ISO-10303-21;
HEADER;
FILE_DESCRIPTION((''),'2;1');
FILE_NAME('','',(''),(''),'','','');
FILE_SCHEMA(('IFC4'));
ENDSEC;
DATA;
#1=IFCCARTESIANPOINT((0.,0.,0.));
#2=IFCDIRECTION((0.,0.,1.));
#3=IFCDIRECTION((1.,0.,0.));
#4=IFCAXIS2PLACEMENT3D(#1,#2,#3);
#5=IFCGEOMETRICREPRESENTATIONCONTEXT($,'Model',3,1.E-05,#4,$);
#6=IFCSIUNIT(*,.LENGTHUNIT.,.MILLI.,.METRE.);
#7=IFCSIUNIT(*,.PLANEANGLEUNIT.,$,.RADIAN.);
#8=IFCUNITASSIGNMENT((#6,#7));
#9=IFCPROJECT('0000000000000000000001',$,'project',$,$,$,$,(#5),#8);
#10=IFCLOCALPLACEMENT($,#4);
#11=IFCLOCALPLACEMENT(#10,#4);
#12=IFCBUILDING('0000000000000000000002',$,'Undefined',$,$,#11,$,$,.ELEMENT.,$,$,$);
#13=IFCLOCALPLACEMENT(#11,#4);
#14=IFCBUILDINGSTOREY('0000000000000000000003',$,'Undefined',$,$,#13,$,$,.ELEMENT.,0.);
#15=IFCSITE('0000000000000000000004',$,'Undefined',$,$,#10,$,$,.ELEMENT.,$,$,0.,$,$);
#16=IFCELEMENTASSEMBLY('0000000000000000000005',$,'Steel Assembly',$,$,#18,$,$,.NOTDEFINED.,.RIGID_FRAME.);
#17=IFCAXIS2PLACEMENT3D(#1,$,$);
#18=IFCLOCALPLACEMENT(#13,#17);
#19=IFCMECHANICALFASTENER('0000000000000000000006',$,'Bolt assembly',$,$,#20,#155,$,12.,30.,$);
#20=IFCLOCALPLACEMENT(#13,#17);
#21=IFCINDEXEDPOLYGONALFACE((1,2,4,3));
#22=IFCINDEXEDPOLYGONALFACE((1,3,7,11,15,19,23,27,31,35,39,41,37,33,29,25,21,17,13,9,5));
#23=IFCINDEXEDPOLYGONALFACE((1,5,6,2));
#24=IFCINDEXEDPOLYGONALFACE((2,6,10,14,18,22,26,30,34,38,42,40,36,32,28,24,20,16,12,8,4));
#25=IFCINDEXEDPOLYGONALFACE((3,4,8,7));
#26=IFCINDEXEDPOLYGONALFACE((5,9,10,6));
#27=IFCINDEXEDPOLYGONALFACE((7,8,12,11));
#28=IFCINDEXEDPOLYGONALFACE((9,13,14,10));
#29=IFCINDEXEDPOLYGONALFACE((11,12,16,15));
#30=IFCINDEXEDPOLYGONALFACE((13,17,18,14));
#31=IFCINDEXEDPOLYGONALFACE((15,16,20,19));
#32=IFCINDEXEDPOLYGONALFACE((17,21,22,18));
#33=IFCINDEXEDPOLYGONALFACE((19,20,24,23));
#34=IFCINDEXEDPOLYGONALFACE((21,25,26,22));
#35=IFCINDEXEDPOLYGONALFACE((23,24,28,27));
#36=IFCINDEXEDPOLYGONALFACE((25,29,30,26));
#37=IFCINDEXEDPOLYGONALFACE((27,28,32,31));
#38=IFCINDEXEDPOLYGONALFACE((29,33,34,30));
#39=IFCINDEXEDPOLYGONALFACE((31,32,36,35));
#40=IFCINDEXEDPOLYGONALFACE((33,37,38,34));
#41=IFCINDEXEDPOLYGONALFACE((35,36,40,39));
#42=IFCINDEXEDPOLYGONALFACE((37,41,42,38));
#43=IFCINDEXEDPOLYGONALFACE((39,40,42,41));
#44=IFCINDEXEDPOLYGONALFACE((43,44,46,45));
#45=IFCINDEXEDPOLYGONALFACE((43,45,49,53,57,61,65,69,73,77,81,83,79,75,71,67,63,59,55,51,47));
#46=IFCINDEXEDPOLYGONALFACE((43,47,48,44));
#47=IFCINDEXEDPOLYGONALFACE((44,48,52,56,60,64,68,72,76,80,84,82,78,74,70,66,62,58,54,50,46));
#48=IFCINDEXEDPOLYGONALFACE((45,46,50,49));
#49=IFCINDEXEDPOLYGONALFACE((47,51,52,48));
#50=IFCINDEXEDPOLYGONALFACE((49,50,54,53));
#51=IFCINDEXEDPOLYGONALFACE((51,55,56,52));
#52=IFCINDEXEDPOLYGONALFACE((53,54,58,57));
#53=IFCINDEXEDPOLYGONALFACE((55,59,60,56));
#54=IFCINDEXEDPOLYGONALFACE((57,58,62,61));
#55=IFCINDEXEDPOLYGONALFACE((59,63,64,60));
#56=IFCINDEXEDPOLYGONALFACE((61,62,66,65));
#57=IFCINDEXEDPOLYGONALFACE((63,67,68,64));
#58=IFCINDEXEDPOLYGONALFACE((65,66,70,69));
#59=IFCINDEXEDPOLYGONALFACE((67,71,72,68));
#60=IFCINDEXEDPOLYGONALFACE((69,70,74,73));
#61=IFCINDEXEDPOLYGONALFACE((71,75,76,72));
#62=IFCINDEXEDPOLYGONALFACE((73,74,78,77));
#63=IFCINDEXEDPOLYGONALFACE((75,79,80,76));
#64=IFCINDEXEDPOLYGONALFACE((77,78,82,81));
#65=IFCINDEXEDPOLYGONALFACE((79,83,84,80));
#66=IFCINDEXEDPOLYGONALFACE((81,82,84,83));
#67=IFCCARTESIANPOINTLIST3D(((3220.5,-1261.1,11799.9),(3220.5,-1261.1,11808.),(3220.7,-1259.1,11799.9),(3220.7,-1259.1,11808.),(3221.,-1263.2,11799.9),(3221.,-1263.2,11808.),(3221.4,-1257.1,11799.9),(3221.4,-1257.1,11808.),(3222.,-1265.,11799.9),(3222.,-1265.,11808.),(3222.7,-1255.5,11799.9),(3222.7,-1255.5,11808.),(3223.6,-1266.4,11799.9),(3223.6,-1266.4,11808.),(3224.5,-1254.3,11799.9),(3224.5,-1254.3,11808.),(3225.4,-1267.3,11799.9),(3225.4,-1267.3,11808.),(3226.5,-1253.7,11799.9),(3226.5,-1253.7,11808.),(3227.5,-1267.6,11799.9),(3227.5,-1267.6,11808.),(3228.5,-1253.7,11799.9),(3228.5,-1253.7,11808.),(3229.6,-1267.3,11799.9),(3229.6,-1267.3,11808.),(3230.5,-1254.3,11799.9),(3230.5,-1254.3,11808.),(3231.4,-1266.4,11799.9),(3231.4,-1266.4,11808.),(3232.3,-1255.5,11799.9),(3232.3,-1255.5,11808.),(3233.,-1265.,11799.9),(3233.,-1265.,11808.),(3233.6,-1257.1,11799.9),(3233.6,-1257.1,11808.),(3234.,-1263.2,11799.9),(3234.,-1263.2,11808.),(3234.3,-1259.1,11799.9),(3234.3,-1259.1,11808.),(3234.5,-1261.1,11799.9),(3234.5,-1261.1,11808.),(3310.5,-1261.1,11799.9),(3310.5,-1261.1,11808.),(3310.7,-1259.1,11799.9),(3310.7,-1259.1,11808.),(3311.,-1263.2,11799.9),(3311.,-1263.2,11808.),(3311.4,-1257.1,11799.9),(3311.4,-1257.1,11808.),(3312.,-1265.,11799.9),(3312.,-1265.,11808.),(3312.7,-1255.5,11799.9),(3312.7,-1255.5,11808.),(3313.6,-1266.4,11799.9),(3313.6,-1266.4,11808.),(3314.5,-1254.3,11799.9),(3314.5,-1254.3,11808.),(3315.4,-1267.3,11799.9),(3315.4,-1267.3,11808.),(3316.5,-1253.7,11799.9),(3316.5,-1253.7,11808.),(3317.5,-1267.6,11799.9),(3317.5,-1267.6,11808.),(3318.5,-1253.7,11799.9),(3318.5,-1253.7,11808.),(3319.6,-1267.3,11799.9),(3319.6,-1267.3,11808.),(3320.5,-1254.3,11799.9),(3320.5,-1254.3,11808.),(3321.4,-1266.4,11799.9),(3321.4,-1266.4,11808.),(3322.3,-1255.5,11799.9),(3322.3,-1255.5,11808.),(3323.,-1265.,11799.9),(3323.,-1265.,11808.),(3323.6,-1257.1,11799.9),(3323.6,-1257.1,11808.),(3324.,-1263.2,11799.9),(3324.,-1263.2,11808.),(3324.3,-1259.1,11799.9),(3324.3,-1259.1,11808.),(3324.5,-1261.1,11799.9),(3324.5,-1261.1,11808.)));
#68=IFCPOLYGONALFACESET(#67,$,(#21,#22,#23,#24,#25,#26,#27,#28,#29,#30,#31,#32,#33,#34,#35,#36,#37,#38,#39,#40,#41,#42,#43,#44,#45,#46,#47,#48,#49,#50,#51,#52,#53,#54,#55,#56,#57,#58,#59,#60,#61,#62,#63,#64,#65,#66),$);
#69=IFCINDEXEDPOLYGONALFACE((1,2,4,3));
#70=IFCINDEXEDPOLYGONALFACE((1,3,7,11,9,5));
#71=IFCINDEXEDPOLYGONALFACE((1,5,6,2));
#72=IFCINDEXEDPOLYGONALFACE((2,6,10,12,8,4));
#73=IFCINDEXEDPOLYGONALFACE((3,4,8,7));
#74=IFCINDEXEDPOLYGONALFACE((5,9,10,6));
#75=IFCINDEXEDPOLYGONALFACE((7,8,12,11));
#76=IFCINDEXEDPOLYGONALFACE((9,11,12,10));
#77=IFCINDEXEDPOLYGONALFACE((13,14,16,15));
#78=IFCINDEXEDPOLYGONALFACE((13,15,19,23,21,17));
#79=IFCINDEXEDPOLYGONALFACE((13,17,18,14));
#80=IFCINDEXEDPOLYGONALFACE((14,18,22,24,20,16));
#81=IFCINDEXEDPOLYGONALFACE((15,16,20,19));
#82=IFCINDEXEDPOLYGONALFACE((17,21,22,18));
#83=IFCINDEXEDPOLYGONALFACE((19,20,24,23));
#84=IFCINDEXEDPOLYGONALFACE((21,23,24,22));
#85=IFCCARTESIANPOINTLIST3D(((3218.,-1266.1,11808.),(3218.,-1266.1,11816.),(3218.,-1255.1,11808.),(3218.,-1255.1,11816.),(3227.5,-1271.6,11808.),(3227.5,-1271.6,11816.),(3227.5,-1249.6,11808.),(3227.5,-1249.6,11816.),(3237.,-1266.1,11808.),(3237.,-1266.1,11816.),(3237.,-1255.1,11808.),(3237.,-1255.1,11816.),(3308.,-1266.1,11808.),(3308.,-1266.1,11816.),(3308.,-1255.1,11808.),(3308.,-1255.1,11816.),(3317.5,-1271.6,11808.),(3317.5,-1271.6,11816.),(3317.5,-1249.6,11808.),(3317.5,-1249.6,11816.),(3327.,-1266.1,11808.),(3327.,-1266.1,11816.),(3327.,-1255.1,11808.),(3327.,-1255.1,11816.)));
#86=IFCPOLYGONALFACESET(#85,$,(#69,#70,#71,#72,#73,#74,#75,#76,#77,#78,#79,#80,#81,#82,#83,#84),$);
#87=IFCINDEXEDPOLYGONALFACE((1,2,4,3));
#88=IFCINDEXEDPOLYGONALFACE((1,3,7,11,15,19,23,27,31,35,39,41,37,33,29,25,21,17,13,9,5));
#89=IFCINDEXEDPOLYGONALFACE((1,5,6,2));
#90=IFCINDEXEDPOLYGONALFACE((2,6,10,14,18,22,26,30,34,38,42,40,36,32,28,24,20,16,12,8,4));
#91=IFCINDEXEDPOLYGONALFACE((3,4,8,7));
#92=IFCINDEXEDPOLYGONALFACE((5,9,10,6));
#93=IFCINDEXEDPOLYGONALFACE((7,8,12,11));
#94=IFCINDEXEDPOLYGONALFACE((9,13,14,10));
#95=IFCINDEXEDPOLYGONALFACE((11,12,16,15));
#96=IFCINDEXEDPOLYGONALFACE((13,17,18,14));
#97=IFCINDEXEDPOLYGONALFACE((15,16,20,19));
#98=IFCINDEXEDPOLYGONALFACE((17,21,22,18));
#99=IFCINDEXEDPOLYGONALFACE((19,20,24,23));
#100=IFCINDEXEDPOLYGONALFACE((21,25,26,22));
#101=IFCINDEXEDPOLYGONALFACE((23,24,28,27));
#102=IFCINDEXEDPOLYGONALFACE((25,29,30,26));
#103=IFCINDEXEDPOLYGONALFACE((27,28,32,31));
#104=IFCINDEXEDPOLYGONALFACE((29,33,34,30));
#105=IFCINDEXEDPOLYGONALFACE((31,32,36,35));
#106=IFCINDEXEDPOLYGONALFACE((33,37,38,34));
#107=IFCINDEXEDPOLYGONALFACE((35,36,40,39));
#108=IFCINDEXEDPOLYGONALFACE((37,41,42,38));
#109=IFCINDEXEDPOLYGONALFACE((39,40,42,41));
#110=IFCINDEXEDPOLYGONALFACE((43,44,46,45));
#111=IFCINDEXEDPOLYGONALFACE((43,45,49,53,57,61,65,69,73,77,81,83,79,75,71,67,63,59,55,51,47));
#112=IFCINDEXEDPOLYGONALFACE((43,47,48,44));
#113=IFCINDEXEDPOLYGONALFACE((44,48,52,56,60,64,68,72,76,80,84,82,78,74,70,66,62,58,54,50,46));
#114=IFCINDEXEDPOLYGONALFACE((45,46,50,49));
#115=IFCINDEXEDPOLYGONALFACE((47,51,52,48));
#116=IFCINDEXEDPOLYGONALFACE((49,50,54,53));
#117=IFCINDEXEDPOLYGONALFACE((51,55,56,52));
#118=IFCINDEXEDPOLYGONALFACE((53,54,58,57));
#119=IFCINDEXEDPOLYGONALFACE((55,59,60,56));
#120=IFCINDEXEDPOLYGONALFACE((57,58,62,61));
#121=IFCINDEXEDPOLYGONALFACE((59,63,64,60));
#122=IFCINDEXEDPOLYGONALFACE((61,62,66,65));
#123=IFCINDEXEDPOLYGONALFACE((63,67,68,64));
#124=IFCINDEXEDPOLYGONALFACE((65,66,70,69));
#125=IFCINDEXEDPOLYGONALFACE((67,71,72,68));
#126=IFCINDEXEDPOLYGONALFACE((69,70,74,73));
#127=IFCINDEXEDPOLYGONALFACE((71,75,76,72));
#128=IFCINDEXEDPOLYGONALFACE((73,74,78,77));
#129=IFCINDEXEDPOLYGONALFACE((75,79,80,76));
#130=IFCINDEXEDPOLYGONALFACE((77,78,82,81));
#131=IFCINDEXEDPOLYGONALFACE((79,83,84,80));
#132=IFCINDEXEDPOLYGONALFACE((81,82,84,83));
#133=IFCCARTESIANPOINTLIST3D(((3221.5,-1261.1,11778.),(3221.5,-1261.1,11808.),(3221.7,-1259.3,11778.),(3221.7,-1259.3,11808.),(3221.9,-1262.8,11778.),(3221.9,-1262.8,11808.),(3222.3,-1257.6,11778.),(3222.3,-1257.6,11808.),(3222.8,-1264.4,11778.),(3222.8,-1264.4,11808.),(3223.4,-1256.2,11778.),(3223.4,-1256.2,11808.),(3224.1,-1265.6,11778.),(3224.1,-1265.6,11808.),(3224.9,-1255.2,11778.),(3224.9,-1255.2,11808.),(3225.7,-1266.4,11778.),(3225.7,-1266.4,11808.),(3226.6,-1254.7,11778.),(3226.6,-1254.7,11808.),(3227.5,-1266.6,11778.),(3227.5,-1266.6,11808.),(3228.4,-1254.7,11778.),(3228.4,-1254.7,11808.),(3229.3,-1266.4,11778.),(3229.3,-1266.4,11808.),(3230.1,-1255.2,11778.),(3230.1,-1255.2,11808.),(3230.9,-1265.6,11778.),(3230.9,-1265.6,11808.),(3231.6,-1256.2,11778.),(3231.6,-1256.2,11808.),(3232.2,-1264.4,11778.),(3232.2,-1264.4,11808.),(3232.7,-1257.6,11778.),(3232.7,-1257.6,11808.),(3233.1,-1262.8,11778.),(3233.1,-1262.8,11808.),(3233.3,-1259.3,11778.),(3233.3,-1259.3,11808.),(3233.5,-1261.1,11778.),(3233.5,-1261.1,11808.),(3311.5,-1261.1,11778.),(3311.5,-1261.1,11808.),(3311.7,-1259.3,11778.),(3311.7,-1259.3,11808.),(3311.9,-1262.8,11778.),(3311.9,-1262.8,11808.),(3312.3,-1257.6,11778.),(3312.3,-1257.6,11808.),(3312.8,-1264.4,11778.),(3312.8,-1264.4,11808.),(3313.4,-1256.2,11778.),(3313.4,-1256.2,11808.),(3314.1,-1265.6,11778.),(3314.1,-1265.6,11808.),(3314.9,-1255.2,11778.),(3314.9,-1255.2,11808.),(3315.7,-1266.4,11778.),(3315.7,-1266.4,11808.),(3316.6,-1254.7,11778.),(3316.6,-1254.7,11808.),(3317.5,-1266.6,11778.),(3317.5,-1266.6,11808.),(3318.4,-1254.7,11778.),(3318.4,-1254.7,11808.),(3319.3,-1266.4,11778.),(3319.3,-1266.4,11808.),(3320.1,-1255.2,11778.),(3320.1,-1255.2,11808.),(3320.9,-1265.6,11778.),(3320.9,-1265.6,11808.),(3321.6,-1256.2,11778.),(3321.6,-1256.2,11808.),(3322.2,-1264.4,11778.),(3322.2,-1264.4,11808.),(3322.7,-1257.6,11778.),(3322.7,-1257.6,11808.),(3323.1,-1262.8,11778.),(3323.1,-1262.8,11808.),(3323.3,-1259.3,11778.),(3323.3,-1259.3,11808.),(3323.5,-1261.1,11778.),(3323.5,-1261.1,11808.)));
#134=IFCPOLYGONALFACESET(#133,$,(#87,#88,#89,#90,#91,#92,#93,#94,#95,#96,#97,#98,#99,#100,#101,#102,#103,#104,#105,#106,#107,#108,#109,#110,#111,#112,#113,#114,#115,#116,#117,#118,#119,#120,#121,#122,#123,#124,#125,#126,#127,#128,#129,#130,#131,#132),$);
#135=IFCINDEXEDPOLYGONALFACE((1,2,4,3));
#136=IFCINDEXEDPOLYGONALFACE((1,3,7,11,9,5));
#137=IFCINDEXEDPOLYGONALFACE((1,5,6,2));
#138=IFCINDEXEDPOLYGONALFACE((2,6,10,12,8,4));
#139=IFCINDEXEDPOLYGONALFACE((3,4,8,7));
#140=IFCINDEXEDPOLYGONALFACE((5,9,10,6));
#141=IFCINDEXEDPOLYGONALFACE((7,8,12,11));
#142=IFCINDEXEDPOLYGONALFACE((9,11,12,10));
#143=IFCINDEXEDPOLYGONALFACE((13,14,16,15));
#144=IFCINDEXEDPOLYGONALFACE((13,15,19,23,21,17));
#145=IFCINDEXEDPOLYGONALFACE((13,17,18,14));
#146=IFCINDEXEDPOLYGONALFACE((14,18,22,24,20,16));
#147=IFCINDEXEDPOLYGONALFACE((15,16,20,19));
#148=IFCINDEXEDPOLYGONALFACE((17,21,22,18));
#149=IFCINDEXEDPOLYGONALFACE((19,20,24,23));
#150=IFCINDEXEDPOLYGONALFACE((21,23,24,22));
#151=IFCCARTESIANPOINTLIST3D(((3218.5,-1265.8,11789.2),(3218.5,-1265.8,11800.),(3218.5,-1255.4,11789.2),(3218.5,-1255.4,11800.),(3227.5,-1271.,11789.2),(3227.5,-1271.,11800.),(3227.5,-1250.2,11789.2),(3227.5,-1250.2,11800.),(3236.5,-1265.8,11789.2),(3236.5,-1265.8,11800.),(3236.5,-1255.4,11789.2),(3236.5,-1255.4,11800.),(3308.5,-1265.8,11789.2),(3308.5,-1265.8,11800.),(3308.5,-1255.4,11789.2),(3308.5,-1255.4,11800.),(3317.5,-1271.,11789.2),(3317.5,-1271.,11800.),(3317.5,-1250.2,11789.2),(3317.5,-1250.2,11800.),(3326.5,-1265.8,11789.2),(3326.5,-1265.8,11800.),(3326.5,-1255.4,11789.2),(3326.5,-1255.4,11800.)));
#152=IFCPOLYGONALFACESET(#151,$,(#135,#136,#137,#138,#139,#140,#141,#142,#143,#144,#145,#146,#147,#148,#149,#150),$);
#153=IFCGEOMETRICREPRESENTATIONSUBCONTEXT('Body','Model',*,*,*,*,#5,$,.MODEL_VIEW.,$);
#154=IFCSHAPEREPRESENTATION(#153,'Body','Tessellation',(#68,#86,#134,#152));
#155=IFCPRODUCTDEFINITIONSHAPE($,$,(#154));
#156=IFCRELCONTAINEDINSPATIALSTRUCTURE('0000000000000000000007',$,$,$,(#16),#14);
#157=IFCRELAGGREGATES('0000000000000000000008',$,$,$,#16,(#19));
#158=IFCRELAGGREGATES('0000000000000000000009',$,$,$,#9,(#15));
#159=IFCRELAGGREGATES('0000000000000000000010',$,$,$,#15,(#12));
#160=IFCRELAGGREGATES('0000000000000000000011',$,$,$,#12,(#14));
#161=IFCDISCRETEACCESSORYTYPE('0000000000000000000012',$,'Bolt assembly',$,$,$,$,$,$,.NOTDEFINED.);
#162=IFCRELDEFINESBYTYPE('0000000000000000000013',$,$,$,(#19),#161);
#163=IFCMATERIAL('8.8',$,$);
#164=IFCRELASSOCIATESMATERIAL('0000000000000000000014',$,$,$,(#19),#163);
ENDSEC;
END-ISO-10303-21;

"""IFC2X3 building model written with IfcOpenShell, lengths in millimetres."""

from ifc_helpers import new_model, si_unit, frame, origin_with_axes, origin_2d_with_axis, place, context, subcontext, project, spatial, polyline, circle, outline, extrude, source, transform, mapped, material, type_object, element, aggregate, save


model = new_model("IFC2X3")

# Units and contexts
model_context = context("Model", 3, precision=1e-05, world=origin_with_axes())
body_context = subcontext(model_context, "Body", "Model", "MODEL_VIEW")
ifc_project = project(units=[si_unit("LENGTHUNIT", "METRE", prefix="MILLI"), si_unit("PLANEANGLEUNIT", "RADIAN")], contexts=[model_context])

# Site, building, storey
site_placement = place(None, origin_with_axes())
site = spatial("IfcSite", under=ifc_project, at=site_placement, Name="Undefined", CompositionType="ELEMENT", RefElevation=0.0)
building_placement = place(site_placement, origin_with_axes())
building = spatial("IfcBuilding", under=site, at=building_placement, Name="Undefined", CompositionType="ELEMENT")
storey_placement = place(building_placement, origin_with_axes())
storey = spatial("IfcBuildingStorey", under=building, at=storey_placement, Name="Undefined", CompositionType="ELEMENT", Elevation=0.0)

# Element assembly, mechanical fastener
assembly_1_placement = place(storey_placement, origin_with_axes())
assembly_1 = element("IfcElementAssembly", 1, at=assembly_1_placement, inside=storey, Name="Steel Assembly", AssemblyPlace="NOTDEFINED", PredefinedType="RIGID_FRAME")
ifc_material_1 = material(Name="8.8")
discrete_accessory_type_1 = type_object("IfcDiscreteAccessoryType", Name="Bolt assembly")
shared_shape_1 = source(origin_with_axes(), body_context, "Body", "SweptSolid", [
    extrude(circle(Radius=7.0, at=origin_2d_with_axis()), frame((0.0, 0.0, 0.0), z_axis=(0.0, 1.0, 0.0), x_axis=(1.0, 0.0, 0.0)), (0.0, 0.0, 1.0), 8.1),
    extrude(outline(polyline([(11.0, 0.0), (5.5, 9.5), (-5.5, 9.5), (-11.0, 0.0), (-5.5, -9.5), (5.5, -9.5), (11.0, 0.0)])), frame((0.0, -8.0, 0.0), z_axis=(0.0, 1.0, 0.0), x_axis=(1.0, 0.0, 0.0)), (0.0, 0.0, 1.0), 8.0),
    extrude(circle(Radius=6.0, at=origin_2d_with_axis()), frame((0.0, 0.0, 0.0), z_axis=(0.0, 1.0, 0.0), x_axis=(1.0, 0.0, 0.0)), (0.0, 0.0, 1.0), 30.0),
    extrude(outline(polyline([(10.4, 0.0), (5.2, 9.0), (-5.2, 9.0), (-10.4, 0.0), (-5.2, -9.0), (5.2, -9.0), (10.4, 0.0)])), frame((0.0, 8.0, 0.0), z_axis=(0.0, 1.0, 0.0), x_axis=(1.0, 0.0, 0.0)), (0.0, 0.0, 1.0), 10.8),
])
mechanical_fastener_1_placement = place(assembly_1_placement, frame((3272.5, -1240.6, 11808.0), z_axis=(1.0, 0.0, 0.0), x_axis=(0.0, -1.0, 0.0)))
mechanical_fastener_1 = element("IfcMechanicalFastener", 2, at=mechanical_fastener_1_placement, type_object=discrete_accessory_type_1, material=ifc_material_1, Name="Bolt assembly", NominalDiameter=12.0, NominalLength=30.0, context=body_context, shape_type="MappedRepresentation", body=[
    mapped(shared_shape_1, transform((20.0, 0.0, -45.0))),
    mapped(shared_shape_1, transform((20.0, 0.0, 45.0))),
])

aggregate(assembly_1, [mechanical_fastener_1])

save(model, "model.ifc")
